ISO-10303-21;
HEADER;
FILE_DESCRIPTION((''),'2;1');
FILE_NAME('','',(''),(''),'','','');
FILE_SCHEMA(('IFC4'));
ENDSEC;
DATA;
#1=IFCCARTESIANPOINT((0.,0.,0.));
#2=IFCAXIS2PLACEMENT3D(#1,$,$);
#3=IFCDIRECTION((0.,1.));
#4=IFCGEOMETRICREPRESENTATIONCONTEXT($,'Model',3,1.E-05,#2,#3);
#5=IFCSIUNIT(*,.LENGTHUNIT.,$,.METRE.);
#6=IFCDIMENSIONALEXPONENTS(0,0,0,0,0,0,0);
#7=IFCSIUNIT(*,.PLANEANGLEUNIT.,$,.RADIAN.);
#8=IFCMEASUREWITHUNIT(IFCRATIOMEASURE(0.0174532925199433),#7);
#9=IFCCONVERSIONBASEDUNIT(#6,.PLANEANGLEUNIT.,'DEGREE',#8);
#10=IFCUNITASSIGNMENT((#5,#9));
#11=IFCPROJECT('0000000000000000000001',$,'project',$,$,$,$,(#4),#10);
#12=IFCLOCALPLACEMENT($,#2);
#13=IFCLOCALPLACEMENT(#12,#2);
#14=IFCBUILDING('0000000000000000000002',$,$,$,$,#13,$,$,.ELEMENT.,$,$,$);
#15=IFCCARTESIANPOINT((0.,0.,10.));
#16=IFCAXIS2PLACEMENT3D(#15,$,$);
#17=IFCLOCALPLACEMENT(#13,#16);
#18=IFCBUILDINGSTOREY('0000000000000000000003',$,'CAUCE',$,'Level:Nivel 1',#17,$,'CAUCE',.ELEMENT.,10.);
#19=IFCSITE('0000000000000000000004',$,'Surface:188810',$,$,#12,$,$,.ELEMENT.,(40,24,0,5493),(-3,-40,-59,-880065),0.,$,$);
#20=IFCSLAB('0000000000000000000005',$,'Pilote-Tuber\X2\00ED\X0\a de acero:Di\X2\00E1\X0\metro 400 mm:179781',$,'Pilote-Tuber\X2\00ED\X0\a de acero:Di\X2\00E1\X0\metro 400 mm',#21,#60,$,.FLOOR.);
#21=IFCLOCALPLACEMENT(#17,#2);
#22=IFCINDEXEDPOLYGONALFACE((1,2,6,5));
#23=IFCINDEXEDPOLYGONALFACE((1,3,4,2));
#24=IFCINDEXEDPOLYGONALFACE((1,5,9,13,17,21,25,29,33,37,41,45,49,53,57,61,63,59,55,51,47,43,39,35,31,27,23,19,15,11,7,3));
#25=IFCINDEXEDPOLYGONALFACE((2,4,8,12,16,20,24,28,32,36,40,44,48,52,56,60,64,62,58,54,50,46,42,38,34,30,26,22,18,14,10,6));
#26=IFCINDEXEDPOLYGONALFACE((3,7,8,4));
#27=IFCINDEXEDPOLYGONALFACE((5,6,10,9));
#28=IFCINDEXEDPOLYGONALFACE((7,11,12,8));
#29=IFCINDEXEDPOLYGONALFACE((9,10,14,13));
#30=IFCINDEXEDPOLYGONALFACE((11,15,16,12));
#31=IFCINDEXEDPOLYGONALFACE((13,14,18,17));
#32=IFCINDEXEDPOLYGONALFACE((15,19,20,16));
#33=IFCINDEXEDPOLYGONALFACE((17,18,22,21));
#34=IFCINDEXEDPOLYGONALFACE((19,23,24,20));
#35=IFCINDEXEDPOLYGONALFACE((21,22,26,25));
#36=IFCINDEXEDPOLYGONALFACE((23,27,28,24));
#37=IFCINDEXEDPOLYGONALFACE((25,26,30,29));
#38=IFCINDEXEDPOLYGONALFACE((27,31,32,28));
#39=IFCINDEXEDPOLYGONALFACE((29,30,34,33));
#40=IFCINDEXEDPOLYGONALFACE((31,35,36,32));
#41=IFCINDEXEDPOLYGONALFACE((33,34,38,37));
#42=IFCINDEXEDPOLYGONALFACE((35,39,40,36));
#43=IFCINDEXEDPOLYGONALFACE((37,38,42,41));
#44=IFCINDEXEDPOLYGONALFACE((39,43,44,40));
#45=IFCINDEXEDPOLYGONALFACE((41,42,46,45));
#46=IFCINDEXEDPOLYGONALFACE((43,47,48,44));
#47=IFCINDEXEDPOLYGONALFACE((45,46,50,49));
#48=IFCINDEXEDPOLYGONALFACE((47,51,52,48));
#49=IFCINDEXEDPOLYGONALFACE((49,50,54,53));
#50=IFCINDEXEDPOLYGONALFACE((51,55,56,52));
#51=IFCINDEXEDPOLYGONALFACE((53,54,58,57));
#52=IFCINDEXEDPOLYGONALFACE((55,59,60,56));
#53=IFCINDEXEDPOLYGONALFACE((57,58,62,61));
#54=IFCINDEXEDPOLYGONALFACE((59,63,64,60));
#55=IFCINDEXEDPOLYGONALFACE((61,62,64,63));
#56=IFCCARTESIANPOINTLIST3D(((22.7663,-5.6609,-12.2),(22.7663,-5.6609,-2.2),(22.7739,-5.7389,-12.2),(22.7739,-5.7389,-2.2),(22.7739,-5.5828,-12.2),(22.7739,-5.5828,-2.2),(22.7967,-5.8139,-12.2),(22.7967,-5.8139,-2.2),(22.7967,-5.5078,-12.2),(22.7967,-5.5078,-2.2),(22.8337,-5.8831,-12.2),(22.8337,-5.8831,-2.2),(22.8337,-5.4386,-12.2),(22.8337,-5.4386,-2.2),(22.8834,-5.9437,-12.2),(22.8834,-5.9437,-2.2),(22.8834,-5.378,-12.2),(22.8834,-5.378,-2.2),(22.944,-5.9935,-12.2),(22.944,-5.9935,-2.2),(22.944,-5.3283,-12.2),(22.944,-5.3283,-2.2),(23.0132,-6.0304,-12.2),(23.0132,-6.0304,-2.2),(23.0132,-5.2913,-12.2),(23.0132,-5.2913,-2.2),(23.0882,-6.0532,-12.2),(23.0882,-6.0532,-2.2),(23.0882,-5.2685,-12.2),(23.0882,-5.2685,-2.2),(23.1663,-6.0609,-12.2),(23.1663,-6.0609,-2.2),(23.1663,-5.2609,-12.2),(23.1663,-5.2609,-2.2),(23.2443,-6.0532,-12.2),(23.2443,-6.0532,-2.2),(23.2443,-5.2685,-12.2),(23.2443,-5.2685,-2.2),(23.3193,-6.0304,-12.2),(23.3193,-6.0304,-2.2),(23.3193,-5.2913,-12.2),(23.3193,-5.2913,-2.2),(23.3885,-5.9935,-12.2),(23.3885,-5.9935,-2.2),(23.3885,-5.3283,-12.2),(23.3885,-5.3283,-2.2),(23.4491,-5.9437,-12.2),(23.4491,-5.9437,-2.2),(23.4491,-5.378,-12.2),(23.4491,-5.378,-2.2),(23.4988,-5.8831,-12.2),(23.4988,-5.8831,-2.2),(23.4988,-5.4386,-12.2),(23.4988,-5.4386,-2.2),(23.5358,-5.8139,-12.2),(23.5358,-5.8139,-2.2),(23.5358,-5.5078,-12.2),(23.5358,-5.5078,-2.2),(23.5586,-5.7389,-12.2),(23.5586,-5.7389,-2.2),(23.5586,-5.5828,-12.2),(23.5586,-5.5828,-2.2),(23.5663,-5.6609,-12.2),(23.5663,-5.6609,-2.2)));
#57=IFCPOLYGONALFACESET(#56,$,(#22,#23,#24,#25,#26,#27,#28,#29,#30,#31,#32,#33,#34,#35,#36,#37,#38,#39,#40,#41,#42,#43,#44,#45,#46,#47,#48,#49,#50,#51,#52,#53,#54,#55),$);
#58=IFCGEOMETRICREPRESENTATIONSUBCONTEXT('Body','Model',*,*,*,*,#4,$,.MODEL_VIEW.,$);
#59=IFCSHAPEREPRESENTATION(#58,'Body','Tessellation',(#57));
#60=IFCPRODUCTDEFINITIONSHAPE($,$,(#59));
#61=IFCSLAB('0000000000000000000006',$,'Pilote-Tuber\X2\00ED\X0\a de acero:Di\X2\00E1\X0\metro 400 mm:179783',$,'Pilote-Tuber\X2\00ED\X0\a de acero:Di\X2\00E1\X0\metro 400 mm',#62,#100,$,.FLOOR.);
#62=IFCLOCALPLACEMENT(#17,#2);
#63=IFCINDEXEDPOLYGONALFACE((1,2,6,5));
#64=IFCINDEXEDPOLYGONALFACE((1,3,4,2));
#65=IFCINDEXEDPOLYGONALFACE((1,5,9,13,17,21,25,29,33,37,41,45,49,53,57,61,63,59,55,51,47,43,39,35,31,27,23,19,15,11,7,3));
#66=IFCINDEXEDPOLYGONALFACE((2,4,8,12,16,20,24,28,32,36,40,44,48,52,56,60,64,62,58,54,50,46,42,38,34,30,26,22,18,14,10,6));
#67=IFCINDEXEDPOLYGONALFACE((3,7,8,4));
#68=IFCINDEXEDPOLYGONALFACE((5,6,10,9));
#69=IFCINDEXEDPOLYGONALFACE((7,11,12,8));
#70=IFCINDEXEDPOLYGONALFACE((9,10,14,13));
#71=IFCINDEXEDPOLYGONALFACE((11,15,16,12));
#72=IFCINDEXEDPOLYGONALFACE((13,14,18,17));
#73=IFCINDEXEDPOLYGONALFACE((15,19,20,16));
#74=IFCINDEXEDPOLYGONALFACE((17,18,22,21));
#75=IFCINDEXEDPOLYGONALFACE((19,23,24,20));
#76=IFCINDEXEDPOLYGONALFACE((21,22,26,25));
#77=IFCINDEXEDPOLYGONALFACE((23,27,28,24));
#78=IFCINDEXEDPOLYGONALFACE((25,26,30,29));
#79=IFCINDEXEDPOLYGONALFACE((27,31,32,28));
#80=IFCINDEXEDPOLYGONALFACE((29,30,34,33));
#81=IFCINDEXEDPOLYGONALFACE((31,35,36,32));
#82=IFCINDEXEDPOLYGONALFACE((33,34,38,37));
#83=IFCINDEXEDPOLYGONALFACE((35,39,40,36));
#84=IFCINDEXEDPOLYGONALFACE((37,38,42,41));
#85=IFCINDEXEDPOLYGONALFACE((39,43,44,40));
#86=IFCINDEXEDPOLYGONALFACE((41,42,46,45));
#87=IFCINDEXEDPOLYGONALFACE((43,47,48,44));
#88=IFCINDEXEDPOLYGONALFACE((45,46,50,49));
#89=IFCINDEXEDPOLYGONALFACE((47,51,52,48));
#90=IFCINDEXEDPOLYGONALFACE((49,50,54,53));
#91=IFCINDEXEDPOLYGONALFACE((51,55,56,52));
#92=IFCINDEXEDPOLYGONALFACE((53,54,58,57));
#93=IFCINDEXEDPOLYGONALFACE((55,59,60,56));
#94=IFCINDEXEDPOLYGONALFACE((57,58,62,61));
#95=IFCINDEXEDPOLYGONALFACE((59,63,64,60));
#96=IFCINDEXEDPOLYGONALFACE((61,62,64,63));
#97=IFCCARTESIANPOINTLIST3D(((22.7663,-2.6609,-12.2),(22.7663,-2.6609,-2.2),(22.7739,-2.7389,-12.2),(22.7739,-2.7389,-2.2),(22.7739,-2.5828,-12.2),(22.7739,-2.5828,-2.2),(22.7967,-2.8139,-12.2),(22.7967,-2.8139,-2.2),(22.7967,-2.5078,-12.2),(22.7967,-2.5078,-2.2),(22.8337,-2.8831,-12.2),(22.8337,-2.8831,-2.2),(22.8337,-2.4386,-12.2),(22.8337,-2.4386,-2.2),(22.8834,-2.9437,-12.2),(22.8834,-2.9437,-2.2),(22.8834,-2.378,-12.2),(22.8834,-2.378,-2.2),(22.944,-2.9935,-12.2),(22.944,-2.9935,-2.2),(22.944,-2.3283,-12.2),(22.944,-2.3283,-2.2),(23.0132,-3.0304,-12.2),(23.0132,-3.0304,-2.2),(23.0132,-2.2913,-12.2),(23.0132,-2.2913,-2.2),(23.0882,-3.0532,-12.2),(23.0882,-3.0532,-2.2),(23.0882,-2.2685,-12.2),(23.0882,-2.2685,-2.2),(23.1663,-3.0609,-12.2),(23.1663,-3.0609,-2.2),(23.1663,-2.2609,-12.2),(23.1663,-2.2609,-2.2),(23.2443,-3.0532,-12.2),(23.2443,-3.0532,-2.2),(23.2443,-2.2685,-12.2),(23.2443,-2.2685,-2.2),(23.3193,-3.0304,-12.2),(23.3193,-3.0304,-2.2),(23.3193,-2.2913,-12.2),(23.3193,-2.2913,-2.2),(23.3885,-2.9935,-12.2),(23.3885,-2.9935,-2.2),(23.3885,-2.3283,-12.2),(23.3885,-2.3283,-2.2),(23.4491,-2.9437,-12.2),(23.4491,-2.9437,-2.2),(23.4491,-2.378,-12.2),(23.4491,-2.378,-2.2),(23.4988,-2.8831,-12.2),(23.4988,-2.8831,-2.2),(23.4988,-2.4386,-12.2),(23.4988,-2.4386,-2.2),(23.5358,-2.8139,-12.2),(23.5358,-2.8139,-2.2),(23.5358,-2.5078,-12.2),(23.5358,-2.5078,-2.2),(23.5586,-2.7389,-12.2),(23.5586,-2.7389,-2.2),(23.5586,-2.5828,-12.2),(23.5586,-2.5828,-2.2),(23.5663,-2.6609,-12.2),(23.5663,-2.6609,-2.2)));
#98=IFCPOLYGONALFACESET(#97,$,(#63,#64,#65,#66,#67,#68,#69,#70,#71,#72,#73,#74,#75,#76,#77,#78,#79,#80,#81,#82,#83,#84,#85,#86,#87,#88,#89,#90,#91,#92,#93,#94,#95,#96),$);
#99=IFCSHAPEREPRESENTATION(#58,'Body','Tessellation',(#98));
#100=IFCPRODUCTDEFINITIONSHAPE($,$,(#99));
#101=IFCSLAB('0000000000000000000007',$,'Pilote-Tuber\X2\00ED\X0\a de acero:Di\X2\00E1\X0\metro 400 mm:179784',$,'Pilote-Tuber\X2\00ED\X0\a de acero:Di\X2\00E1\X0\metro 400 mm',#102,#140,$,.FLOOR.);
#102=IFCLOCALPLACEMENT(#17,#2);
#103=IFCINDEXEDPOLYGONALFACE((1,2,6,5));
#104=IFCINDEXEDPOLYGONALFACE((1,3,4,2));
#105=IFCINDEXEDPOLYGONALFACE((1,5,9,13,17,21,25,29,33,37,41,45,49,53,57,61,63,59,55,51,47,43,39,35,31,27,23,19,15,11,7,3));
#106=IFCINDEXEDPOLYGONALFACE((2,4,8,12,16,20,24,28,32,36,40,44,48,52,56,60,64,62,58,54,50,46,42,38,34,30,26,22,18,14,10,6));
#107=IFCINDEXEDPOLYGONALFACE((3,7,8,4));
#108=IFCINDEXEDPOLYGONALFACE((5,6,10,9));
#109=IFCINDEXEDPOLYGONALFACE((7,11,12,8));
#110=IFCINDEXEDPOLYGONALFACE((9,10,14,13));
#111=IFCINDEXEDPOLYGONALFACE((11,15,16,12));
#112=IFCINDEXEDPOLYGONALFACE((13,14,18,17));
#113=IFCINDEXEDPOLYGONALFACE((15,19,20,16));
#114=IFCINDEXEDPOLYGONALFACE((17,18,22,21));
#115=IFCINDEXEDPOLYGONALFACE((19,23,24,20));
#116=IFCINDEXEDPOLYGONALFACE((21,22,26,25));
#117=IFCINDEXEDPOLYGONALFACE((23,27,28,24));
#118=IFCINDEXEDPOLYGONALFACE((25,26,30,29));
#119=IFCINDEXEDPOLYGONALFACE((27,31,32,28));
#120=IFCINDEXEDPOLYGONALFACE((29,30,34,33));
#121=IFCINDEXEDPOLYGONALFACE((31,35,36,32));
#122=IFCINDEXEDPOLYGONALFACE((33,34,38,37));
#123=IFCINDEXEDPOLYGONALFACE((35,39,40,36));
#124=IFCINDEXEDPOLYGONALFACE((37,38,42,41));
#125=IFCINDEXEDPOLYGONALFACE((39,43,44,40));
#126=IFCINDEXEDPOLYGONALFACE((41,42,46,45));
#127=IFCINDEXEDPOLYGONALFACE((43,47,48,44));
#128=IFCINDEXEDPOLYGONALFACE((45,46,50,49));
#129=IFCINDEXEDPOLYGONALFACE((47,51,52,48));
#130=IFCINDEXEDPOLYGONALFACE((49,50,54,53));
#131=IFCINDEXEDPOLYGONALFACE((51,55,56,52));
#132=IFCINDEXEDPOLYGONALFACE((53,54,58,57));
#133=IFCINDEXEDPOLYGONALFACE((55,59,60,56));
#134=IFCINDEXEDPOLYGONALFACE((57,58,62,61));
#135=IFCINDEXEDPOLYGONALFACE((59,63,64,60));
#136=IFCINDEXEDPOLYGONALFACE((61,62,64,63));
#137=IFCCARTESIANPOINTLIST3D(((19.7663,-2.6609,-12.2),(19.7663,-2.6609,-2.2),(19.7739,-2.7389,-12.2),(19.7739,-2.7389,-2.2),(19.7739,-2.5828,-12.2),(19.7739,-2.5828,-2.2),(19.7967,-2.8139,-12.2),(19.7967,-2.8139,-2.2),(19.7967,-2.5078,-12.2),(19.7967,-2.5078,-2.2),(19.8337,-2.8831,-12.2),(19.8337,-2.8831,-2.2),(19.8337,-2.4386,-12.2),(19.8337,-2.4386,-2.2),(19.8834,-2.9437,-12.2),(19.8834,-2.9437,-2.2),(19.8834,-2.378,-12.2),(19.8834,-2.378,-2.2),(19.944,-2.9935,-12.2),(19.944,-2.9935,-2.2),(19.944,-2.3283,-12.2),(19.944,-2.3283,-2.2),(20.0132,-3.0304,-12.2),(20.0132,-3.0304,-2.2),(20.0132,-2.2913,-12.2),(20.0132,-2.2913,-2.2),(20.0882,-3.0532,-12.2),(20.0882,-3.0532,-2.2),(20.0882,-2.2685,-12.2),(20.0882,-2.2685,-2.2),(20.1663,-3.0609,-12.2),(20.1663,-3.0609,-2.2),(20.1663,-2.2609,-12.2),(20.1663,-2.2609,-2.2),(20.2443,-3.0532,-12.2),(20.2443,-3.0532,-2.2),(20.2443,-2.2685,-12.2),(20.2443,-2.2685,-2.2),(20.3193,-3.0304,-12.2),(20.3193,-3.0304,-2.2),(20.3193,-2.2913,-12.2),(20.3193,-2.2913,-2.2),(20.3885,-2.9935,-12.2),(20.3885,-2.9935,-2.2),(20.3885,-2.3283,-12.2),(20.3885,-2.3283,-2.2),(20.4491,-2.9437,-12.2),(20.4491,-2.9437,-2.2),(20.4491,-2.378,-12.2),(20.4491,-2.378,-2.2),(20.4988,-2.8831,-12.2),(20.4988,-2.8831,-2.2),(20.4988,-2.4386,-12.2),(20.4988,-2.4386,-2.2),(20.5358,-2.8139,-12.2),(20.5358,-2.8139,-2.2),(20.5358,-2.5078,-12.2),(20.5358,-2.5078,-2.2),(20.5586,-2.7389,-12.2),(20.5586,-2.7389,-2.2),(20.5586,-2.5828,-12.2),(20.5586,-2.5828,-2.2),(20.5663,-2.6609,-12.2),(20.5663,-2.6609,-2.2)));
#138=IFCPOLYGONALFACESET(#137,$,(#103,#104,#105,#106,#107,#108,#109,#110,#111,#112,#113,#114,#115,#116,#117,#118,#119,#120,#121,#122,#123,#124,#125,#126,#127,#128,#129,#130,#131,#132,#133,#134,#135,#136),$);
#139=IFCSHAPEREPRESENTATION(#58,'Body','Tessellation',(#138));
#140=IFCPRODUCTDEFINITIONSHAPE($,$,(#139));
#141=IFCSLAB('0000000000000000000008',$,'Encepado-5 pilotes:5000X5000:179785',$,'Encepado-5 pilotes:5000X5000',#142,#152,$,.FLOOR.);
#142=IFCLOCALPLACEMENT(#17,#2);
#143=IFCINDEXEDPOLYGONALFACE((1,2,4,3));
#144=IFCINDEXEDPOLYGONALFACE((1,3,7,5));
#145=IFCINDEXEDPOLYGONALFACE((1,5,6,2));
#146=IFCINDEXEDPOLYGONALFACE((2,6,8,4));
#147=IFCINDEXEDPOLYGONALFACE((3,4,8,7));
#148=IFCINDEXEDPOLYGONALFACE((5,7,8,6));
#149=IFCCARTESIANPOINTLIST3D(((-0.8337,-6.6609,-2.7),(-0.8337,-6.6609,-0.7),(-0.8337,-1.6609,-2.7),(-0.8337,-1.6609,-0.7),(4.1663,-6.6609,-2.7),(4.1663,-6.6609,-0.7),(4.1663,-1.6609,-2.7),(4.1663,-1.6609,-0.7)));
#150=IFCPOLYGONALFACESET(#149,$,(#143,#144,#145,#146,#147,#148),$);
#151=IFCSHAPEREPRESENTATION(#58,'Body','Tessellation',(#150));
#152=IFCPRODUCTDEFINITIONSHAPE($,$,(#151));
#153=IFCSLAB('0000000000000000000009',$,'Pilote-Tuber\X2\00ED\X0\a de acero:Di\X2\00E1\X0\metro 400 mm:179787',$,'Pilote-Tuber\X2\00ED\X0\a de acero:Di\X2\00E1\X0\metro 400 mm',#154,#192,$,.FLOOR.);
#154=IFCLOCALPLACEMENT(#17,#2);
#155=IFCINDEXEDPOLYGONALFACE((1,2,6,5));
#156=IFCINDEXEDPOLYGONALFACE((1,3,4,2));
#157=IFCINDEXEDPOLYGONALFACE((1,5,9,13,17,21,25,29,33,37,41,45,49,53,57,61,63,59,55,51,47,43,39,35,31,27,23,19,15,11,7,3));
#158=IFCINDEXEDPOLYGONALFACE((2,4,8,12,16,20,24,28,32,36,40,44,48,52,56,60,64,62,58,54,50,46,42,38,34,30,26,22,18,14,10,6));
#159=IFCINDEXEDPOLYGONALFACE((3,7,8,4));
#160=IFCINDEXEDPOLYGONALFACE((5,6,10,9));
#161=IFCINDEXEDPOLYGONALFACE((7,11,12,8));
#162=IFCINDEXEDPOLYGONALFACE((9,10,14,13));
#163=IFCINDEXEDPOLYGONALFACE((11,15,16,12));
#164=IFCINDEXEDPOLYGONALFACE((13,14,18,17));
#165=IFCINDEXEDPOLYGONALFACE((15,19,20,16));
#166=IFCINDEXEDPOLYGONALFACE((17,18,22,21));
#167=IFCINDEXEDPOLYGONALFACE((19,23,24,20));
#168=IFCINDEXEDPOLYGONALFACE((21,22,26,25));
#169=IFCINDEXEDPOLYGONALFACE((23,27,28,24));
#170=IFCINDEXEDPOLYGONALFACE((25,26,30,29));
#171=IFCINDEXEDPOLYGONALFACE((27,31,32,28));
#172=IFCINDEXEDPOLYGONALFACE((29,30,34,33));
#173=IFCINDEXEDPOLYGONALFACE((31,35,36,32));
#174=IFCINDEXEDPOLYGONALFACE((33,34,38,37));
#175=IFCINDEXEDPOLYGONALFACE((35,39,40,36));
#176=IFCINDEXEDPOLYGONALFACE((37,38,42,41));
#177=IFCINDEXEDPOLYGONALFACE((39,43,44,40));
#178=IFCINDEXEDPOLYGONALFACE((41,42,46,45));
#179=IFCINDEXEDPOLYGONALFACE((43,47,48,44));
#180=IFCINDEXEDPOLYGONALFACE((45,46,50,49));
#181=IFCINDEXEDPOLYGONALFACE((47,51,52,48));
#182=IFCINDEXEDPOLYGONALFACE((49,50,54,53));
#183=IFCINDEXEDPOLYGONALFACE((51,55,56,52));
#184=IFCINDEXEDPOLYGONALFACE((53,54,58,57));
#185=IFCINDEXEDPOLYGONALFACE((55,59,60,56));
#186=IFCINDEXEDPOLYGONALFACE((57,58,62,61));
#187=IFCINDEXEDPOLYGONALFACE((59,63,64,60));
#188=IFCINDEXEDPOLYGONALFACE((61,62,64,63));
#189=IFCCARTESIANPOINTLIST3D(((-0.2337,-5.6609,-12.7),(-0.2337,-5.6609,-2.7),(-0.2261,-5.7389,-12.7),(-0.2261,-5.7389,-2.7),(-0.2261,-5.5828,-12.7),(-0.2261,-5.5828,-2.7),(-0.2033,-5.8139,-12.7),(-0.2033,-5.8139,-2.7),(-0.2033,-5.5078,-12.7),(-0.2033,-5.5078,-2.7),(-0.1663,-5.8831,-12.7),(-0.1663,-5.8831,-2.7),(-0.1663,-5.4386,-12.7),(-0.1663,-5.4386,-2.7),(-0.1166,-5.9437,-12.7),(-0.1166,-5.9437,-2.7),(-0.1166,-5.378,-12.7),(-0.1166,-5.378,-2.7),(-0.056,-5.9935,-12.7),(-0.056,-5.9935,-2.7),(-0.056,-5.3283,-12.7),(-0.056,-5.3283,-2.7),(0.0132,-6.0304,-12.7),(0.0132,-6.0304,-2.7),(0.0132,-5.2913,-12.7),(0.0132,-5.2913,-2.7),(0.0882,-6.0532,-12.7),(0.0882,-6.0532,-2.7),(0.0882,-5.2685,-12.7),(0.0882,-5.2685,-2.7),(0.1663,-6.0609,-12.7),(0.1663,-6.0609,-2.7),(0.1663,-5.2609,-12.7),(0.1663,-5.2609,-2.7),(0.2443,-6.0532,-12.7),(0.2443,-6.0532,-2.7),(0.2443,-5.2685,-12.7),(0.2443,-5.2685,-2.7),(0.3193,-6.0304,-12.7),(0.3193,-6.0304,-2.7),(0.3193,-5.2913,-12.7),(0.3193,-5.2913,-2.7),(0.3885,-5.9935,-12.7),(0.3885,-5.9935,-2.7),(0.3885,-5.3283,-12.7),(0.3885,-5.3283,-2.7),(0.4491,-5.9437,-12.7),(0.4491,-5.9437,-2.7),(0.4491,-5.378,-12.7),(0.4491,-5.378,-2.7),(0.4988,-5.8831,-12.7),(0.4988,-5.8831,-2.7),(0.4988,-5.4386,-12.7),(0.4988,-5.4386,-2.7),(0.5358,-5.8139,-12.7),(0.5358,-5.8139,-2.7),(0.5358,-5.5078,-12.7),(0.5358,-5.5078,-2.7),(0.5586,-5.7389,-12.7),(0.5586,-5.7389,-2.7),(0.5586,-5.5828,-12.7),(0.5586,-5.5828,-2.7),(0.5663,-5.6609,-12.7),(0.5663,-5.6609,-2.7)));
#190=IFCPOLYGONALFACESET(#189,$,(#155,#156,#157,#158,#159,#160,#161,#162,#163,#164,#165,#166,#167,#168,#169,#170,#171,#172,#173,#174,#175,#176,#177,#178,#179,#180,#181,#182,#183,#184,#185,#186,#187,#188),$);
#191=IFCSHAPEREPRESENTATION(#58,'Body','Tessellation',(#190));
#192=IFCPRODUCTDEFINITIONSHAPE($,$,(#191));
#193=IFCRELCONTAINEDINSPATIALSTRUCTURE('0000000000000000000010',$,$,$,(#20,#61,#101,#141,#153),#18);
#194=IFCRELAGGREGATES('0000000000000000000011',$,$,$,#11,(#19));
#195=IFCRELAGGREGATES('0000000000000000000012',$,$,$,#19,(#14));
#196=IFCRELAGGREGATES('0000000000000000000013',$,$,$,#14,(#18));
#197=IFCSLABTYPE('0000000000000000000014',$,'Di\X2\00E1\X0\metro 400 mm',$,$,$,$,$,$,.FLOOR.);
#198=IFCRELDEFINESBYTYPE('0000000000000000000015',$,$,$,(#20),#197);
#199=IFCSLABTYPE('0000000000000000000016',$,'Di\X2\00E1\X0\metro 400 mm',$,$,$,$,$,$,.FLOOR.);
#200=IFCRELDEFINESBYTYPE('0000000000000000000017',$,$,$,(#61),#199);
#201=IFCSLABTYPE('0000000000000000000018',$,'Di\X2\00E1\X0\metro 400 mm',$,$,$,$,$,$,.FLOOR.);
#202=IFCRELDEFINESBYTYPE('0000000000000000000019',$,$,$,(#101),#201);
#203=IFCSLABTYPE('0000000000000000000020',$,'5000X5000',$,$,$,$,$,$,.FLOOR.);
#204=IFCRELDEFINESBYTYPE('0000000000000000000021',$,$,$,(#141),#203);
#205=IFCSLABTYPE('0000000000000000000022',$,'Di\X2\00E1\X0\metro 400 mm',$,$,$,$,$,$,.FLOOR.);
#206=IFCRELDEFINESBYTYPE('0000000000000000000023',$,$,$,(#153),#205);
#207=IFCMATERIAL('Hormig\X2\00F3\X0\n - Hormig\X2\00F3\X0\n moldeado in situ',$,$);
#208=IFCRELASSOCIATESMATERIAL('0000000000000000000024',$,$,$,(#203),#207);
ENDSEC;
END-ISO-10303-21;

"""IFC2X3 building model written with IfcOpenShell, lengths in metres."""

from ifc_helpers import new_model, entity, si_unit, converted_unit, direction, frame, frame_2d, origin, place, context, subcontext, project, spatial, rectangle, circle, extrude, material, type_object, element, save


model = new_model("IFC2X3")

# Units and contexts
model_context = context("Model", 3, precision=1e-05, world=origin(), true_north=direction((0.0, 1.0)))
body_context = subcontext(model_context, "Body", "Model", "MODEL_VIEW")
ifc_project = project(units=[si_unit("LENGTHUNIT", "METRE"), converted_unit("PLANEANGLEUNIT", "DEGREE", entity("IfcRatioMeasure", 0.0174532925199433), si_unit("PLANEANGLEUNIT", "RADIAN"), dimensions=[0, 0, 0, 0, 0, 0, 0])], contexts=[model_context])

# Site, building, storey
site_placement = place(None, origin())
site = spatial("IfcSite", under=ifc_project, at=site_placement, Name="Surface:188810", CompositionType="ELEMENT", RefLatitude=(40, 24, 0, 5493), RefLongitude=(-3, -40, -59, -880065), RefElevation=0.0)
building_placement = place(site_placement, origin())
building = spatial("IfcBuilding", under=site, at=building_placement, CompositionType="ELEMENT")
storey_placement = place(building_placement, frame((0.0, 0.0, 10.0)))
storey = spatial("IfcBuildingStorey", under=building, at=storey_placement, Name="CAUCE", ObjectType="Level:Nivel 1", LongName="CAUCE", CompositionType="ELEMENT", Elevation=10.0)

# Slabs
ifc_material = material(Name="Hormigón - Hormigón moldeado in situ")
slab_type_1 = type_object("IfcSlabType", Name="Diámetro 400 mm", PredefinedType="FLOOR")
slab_1_placement = place(storey_placement, origin())
element("IfcSlab", 1, at=slab_1_placement, inside=storey, type_object=slab_type_1, Name="Pilote-Tubería de acero:Diámetro 400 mm:179781", ObjectType="Pilote-Tubería de acero:Diámetro 400 mm", PredefinedType="FLOOR", context=body_context, shape_type="SweptSolid", body=[
    extrude(circle(Radius=0.4, at=frame_2d((0.0, 0.0), x_axis=(1.0, 0.0))), frame((23.1663, -5.6609, -12.2)), (0.0, 0.0, 1.0), 10.0),
])
slab_type_2 = type_object("IfcSlabType", Name="Diámetro 400 mm", PredefinedType="FLOOR")
slab_2_placement = place(storey_placement, origin())
element("IfcSlab", 2, at=slab_2_placement, inside=storey, type_object=slab_type_2, Name="Pilote-Tubería de acero:Diámetro 400 mm:179783", ObjectType="Pilote-Tubería de acero:Diámetro 400 mm", PredefinedType="FLOOR", context=body_context, shape_type="SweptSolid", body=[
    extrude(circle(Radius=0.4, at=frame_2d((0.0, 0.0), x_axis=(1.0, 0.0))), frame((23.1663, -2.6609, -12.2)), (0.0, 0.0, 1.0), 10.0),
])
slab_type_3 = type_object("IfcSlabType", Name="Diámetro 400 mm", PredefinedType="FLOOR")
slab_3_placement = place(storey_placement, origin())
element("IfcSlab", 3, at=slab_3_placement, inside=storey, type_object=slab_type_3, Name="Pilote-Tubería de acero:Diámetro 400 mm:179784", ObjectType="Pilote-Tubería de acero:Diámetro 400 mm", PredefinedType="FLOOR", context=body_context, shape_type="SweptSolid", body=[
    extrude(circle(Radius=0.4, at=frame_2d((0.0, 0.0), x_axis=(1.0, 0.0))), frame((20.1663, -2.6609, -12.2)), (0.0, 0.0, 1.0), 10.0),
])
slab_type_4 = type_object("IfcSlabType", Name="5000X5000", PredefinedType="FLOOR", material=ifc_material)
slab_4_placement = place(storey_placement, origin())
element("IfcSlab", 4, at=slab_4_placement, inside=storey, type_object=slab_type_4, Name="Encepado-5 pilotes:5000X5000:179785", ObjectType="Encepado-5 pilotes:5000X5000", PredefinedType="FLOOR", context=body_context, shape_type="SweptSolid", body=[
    extrude(rectangle(XDim=5.0, YDim=5.0, at=frame_2d((0.0, 0.0), x_axis=(1.0, 0.0))), frame((1.6663, -4.1609, -2.7), z_axis=(0.0, 0.0, 1.0), x_axis=(-1.0, 0.0, 0.0)), (0.0, 0.0, 1.0), 2.0),
])
slab_type_5 = type_object("IfcSlabType", Name="Diámetro 400 mm", PredefinedType="FLOOR")
slab_5_placement = place(storey_placement, origin())
element("IfcSlab", 5, at=slab_5_placement, inside=storey, type_object=slab_type_5, Name="Pilote-Tubería de acero:Diámetro 400 mm:179787", ObjectType="Pilote-Tubería de acero:Diámetro 400 mm", PredefinedType="FLOOR", context=body_context, shape_type="SweptSolid", body=[
    extrude(circle(Radius=0.4, at=frame_2d((0.0, 0.0), x_axis=(1.0, 0.0))), frame((0.1663, -5.6609, -12.7)), (0.0, 0.0, 1.0), 10.0),
])

save(model, "model.ifc")
